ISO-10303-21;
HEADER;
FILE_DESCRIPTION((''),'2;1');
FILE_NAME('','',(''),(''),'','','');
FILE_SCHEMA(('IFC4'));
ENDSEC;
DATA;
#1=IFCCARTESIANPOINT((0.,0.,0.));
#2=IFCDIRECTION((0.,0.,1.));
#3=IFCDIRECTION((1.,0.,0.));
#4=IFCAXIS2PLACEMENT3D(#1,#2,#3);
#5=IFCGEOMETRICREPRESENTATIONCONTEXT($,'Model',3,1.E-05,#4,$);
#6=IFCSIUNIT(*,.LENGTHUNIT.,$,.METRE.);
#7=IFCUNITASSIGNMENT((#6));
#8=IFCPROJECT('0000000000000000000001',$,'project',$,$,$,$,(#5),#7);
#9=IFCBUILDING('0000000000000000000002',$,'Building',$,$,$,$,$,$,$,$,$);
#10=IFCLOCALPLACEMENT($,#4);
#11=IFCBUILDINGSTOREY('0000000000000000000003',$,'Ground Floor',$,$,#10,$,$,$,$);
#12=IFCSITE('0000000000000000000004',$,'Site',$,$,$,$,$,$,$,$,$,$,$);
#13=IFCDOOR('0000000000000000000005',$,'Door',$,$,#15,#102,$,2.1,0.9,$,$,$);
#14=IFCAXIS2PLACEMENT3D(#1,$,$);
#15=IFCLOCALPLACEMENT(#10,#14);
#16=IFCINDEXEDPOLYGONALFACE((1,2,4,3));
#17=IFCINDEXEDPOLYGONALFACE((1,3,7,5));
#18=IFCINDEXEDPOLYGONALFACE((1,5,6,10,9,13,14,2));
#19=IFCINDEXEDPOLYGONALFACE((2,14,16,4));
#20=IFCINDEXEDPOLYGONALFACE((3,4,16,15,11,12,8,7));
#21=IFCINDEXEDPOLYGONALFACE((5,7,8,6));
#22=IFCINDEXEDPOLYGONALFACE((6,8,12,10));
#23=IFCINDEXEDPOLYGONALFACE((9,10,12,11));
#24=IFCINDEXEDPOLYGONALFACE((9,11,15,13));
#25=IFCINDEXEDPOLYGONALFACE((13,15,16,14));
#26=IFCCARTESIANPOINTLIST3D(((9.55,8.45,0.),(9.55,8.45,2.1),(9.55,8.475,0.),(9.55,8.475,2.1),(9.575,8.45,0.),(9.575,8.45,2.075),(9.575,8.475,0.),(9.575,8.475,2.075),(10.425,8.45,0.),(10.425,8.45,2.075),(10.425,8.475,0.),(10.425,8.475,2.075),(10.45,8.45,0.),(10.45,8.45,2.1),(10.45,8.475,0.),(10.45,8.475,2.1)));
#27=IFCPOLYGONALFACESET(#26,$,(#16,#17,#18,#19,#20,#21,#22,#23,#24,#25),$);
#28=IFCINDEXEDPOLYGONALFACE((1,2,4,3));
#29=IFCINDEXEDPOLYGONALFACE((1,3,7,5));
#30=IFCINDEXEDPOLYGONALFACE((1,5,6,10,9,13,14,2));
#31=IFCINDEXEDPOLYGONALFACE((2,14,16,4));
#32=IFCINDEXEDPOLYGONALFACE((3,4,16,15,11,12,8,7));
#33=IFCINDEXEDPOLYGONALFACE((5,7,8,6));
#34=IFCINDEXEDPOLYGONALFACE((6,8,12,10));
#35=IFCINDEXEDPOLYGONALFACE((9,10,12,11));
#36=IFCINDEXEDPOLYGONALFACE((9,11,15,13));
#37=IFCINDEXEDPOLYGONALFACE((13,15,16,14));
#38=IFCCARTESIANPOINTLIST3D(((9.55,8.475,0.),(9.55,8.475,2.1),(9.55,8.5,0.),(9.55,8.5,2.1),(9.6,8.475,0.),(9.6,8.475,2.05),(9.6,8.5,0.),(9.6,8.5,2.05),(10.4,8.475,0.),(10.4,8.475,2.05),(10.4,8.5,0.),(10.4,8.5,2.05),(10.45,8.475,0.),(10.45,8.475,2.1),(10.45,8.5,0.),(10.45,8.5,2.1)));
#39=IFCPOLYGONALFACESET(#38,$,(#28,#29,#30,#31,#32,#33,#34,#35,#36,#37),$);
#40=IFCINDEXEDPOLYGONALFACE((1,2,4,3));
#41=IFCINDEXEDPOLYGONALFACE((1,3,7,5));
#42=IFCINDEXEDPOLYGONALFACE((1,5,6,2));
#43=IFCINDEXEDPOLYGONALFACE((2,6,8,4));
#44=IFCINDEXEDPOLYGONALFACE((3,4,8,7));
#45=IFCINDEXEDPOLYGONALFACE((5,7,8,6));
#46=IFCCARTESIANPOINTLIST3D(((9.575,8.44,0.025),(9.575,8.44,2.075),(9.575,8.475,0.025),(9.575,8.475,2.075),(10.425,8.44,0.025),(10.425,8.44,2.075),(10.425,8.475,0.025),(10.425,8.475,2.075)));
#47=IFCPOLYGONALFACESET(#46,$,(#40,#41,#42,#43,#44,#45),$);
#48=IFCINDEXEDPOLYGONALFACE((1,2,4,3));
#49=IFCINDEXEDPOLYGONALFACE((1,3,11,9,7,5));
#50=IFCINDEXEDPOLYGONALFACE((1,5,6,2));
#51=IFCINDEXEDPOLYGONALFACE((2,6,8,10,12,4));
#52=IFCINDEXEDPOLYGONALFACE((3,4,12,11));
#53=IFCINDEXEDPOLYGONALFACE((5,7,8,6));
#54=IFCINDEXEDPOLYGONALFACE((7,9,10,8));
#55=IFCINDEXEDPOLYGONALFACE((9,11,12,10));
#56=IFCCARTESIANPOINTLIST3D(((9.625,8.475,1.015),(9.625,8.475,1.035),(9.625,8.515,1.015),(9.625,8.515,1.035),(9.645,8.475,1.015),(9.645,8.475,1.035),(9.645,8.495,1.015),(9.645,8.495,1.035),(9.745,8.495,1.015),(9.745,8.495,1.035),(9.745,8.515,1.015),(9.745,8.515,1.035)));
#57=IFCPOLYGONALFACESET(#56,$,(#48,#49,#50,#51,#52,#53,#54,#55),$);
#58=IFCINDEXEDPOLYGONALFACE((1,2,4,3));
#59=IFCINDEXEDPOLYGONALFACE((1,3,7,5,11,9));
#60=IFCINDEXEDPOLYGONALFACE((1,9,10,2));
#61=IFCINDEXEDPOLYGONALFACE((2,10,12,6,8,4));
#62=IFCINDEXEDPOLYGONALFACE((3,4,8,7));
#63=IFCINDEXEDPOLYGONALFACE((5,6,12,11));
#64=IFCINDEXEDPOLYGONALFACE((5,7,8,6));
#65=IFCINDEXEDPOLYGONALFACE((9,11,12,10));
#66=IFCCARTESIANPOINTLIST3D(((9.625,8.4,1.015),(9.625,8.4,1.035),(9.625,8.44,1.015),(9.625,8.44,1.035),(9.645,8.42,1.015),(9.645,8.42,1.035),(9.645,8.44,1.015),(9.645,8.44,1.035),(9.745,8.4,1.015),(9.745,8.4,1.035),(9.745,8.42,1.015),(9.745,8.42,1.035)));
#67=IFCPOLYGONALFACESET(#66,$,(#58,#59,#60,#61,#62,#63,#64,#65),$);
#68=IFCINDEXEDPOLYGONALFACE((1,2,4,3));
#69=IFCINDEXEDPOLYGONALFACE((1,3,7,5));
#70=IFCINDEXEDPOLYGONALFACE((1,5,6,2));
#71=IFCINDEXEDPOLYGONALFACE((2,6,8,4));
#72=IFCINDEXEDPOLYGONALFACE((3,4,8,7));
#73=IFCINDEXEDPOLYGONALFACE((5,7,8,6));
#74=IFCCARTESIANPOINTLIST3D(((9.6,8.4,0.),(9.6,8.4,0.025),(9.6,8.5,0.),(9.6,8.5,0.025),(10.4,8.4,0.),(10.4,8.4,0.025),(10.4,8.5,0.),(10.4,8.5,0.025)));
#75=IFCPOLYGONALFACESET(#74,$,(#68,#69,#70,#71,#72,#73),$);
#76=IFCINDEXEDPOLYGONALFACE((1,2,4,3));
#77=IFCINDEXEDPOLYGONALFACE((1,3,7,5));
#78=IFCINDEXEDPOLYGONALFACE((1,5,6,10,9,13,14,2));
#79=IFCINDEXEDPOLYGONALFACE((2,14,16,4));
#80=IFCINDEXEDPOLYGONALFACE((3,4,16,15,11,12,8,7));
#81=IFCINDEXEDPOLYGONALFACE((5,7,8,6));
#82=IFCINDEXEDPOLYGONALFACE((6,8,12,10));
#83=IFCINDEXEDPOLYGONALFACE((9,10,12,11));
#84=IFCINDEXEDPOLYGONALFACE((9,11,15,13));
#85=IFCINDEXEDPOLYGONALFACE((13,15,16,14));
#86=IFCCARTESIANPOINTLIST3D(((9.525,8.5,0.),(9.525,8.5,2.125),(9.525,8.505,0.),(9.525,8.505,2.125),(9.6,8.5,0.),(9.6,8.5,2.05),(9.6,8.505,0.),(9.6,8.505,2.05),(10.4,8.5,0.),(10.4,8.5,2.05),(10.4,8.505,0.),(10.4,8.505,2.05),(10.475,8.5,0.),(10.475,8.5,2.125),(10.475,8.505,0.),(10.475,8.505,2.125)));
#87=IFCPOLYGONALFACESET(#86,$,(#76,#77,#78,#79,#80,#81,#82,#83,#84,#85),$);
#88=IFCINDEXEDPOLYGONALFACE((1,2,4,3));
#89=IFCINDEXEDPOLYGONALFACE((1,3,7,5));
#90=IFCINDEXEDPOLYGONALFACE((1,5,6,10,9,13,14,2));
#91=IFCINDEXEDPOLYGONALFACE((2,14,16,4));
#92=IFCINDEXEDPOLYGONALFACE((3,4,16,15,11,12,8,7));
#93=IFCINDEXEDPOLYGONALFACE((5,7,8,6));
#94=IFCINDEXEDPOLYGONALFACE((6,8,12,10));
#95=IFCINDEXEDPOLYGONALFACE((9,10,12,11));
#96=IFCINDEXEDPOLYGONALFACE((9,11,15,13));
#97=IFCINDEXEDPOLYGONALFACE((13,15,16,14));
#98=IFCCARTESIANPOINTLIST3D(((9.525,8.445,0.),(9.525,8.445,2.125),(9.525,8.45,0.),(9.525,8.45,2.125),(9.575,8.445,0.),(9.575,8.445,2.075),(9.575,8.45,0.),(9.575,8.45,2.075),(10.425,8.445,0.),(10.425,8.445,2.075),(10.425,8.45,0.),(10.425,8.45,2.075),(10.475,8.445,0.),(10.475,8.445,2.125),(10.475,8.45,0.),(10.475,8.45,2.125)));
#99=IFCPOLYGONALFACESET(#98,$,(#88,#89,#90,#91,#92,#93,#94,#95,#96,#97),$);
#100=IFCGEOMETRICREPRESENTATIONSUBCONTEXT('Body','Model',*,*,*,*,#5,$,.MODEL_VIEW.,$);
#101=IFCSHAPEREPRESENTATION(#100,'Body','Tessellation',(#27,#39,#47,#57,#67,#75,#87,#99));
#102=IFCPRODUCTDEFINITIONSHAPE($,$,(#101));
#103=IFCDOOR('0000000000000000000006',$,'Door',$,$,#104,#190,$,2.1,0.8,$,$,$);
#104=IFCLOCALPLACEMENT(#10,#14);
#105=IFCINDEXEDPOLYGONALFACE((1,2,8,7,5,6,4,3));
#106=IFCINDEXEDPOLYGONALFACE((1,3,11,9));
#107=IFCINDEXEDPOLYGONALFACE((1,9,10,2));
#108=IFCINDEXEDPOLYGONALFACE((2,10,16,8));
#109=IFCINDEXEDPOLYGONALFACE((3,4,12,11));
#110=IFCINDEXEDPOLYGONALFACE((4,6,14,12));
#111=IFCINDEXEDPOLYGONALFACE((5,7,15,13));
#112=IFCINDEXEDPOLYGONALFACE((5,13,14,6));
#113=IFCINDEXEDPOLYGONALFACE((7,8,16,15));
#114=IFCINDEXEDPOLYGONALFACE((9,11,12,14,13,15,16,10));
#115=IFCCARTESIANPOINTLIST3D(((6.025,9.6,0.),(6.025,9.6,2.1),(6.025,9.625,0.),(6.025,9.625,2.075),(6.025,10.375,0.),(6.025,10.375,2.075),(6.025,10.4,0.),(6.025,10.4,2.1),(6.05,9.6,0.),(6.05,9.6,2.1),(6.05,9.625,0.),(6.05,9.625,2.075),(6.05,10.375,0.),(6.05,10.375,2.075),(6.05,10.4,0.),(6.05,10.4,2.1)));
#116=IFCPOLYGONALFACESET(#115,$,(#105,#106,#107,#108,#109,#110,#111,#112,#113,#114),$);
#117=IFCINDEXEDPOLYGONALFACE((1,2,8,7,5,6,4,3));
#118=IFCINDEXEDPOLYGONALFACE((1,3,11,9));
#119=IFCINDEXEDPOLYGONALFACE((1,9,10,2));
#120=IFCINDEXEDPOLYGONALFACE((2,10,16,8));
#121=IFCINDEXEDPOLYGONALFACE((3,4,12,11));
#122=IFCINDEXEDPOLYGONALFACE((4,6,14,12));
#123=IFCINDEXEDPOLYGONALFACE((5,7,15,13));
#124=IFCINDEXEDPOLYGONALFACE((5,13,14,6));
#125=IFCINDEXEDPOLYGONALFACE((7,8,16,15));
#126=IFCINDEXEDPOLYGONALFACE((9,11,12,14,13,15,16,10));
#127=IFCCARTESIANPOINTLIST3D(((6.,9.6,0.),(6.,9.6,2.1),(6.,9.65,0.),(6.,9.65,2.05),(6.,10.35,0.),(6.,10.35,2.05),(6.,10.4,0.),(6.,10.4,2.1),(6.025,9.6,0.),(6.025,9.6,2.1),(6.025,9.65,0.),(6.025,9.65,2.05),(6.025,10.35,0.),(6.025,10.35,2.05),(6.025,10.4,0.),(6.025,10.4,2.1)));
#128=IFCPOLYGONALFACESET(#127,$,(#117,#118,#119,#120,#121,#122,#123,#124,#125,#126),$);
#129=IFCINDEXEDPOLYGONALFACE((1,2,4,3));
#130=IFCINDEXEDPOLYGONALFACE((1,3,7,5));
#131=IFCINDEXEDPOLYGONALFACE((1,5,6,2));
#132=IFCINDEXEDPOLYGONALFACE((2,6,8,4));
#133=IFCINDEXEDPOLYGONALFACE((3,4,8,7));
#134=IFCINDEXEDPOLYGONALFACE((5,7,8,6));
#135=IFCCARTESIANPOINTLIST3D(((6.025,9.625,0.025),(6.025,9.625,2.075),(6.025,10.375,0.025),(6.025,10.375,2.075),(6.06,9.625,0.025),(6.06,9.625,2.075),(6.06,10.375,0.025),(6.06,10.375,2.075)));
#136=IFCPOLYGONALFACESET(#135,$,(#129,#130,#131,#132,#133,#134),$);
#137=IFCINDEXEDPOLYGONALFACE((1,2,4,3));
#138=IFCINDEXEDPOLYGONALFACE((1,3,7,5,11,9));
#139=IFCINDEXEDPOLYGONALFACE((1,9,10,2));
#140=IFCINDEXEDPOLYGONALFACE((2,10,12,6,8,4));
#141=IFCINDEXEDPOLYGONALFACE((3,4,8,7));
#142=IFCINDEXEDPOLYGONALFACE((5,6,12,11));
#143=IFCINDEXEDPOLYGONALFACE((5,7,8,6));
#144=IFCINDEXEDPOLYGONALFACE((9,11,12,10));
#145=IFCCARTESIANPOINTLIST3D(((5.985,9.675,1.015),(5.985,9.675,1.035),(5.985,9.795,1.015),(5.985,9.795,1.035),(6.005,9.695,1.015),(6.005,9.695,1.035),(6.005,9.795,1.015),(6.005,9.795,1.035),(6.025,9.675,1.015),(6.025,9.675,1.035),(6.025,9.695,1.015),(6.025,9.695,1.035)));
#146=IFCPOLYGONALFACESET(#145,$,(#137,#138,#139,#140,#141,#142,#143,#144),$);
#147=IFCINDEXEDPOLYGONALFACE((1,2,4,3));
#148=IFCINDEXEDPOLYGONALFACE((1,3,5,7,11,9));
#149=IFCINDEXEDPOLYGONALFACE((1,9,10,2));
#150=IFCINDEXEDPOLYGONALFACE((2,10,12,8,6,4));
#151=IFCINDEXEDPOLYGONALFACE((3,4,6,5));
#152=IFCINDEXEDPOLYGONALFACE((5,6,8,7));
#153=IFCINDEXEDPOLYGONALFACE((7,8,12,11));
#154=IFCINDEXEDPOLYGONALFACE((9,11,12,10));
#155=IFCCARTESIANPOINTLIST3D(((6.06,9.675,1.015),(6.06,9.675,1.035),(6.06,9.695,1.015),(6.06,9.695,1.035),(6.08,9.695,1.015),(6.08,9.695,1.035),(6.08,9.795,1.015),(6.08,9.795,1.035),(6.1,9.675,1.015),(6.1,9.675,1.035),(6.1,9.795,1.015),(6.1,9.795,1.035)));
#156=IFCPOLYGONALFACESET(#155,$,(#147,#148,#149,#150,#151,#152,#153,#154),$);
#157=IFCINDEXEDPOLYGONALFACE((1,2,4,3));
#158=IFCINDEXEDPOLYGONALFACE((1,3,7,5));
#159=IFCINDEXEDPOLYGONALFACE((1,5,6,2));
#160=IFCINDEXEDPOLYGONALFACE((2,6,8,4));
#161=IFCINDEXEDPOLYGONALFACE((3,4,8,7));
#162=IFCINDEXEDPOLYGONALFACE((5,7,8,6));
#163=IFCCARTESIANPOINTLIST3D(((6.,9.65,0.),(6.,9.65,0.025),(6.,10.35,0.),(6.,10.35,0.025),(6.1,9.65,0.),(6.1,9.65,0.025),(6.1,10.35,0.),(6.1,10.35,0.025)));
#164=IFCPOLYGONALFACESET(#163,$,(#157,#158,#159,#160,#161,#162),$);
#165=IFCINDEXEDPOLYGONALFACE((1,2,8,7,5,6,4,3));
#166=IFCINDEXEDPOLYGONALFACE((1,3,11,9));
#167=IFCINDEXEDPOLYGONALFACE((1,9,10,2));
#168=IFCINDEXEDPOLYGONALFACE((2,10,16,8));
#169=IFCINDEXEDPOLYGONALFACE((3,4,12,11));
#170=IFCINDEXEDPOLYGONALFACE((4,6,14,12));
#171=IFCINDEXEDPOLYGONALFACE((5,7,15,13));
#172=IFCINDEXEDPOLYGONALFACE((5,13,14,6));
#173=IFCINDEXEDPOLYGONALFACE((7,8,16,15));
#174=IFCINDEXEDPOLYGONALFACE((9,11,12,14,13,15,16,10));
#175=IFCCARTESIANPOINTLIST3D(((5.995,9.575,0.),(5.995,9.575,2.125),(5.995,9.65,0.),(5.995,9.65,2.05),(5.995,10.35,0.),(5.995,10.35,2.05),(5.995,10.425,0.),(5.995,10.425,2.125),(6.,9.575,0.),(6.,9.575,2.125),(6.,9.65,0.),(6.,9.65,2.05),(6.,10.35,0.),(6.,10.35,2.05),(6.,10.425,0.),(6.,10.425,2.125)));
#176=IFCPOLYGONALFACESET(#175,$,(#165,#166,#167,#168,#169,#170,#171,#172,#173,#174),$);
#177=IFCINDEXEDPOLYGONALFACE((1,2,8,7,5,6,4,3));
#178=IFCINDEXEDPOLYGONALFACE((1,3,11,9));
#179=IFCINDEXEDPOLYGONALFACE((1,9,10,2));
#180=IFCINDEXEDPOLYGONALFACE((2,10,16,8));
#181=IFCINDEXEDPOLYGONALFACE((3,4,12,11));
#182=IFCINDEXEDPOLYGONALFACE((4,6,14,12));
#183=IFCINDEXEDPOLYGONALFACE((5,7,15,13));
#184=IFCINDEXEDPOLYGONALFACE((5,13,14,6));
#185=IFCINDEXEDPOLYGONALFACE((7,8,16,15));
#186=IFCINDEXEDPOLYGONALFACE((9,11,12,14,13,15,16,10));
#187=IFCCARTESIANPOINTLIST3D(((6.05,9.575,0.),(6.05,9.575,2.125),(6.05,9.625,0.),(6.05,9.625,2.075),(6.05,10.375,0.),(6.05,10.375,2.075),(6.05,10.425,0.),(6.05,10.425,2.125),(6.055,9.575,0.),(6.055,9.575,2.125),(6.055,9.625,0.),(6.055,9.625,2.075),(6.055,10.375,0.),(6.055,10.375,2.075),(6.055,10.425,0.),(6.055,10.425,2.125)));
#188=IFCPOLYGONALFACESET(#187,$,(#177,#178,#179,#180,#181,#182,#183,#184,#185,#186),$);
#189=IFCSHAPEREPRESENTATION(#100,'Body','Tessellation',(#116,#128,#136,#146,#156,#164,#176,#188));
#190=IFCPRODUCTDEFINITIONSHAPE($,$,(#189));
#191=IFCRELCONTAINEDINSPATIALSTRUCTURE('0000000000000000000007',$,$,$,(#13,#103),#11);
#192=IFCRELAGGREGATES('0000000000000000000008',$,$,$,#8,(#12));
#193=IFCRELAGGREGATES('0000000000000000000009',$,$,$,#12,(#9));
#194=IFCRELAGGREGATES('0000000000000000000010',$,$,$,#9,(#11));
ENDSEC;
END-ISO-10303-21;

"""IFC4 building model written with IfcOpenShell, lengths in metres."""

from ifc_helpers import new_model, si_unit, frame, origin_with_axes, place, context, subcontext, project, spatial, line, indexed_curve, outline, extrude, element, save


model = new_model("IFC4")

# Units and contexts
model_context = context("Model", 3, precision=1e-05, world=origin_with_axes())
body_context = subcontext(model_context, "Body", "Model", "MODEL_VIEW")
ifc_project = project(units=[si_unit("LENGTHUNIT", "METRE")], contexts=[model_context])

# Site, building, storey
site = spatial("IfcSite", under=ifc_project, Name="Site")
building = spatial("IfcBuilding", under=site, Name="Building")
storey_placement = place(None, origin_with_axes())
storey = spatial("IfcBuildingStorey", under=building, at=storey_placement, Name="Ground Floor")

# Doors
door_1_placement = place(storey_placement, frame((10.45, 8.5, 0.0), z_axis=(0.0, 0.0, 1.0), x_axis=(-1.0, 0.0, 0.0)))
element("IfcDoor", 1, at=door_1_placement, inside=storey, Name="Door", OverallHeight=2.1, OverallWidth=0.9, context=body_context, shape_type="SweptSolid", body=[
    extrude(outline(indexed_curve([(0.0, 0.0), (0.0, 2.1), (0.9, 2.1), (0.9, 0.0), (0.875, 0.0), (0.875, 2.075), (0.025, 2.075), (0.025, 0.0)], segments=[line(1, 2, 3, 4, 5, 6, 7, 8, 1)])), frame((0.0, 0.025, 0.0), z_axis=(0.0, -1.0, 0.0), x_axis=(1.0, 0.0, 0.0)), (0.0, 0.0, -1.0), 0.025),
    extrude(outline(indexed_curve([(0.0, 0.0), (0.0, 2.1), (0.9, 2.1), (0.9, 0.0), (0.85, 0.0), (0.85, 2.05), (0.05, 2.05), (0.05, 0.0)], segments=[line(1, 2, 3, 4, 5, 6, 7, 8, 1)])), frame((0.0, 0.0, 0.0), z_axis=(0.0, -1.0, 0.0), x_axis=(1.0, 0.0, 0.0)), (0.0, 0.0, -1.0), 0.025),
    extrude(outline(indexed_curve([(0.0, 0.0), (0.85, 0.0), (0.85, 0.035), (0.0, 0.035)], segments=[line(1, 2, 3, 4, 1)])), frame((0.025, 0.025, 0.025), z_axis=(0.0, 0.0, 1.0), x_axis=(1.0, 0.0, 0.0)), (0.0, 0.0, 1.0), 2.05),
    extrude(outline(indexed_curve([(0.0, 0.0), (0.0, -0.04), (-0.12, -0.04), (-0.12, -0.02), (-0.02, -0.02), (-0.02, 0.0)], segments=[line(1, 2, 3, 4, 5, 6, 1)])), frame((0.825, 0.025, 1.015), z_axis=(0.0, 0.0, 1.0), x_axis=(1.0, 0.0, 0.0)), (0.0, 0.0, 1.0), 0.02),
    extrude(outline(indexed_curve([(0.0, 0.0), (0.0, 0.04), (-0.12, 0.04), (-0.12, 0.02), (-0.02, 0.02), (-0.02, 0.0)], segments=[line(1, 2, 3, 4, 5, 6, 1)])), frame((0.825, 0.06, 1.015), z_axis=(0.0, 0.0, 1.0), x_axis=(1.0, 0.0, 0.0)), (0.0, 0.0, 1.0), 0.02),
    extrude(outline(indexed_curve([(0.0, 0.0), (0.8, 0.0), (0.8, 0.1), (0.0, 0.1)], segments=[line(1, 2, 3, 4, 1)])), frame((0.05, 0.0, 0.0), z_axis=(0.0, 0.0, 1.0), x_axis=(1.0, 0.0, 0.0)), (0.0, 0.0, 1.0), 0.025),
    extrude(outline(indexed_curve([(0.0, 0.0), (0.0, 2.125), (0.95, 2.125), (0.95, 0.0), (0.875, 0.0), (0.875, 2.05), (0.075, 2.05), (0.075, 0.0)], segments=[line(1, 2, 3, 4, 5, 6, 7, 8, 1)])), frame((-0.025, -0.005, 0.0), z_axis=(0.0, -1.0, 0.0), x_axis=(1.0, 0.0, 0.0)), (0.0, 0.0, -1.0), 0.005),
    extrude(outline(indexed_curve([(0.0, 0.0), (0.0, 2.125), (0.95, 2.125), (0.95, 0.0), (0.9, 0.0), (0.9, 2.075), (0.05, 2.075), (0.05, 0.0)], segments=[line(1, 2, 3, 4, 5, 6, 7, 8, 1)])), frame((-0.025, 0.05, 0.0), z_axis=(0.0, -1.0, 0.0), x_axis=(1.0, 0.0, 0.0)), (0.0, 0.0, -1.0), 0.005),
])
door_2_placement = place(storey_placement, frame((6.0, 10.4, 0.0), z_axis=(0.0, 0.0, 1.0), x_axis=(0.0, -1.0, 0.0)))
element("IfcDoor", 2, at=door_2_placement, inside=storey, Name="Door", OverallHeight=2.1, OverallWidth=0.8, context=body_context, shape_type="SweptSolid", body=[
    extrude(outline(indexed_curve([(0.0, 0.0), (0.0, 2.1), (0.8, 2.1), (0.8, 0.0), (0.775, 0.0), (0.775, 2.075), (0.025, 2.075), (0.025, 0.0)], segments=[line(1, 2, 3, 4, 5, 6, 7, 8, 1)])), frame((0.0, 0.025, 0.0), z_axis=(0.0, -1.0, 0.0), x_axis=(1.0, 0.0, 0.0)), (0.0, 0.0, -1.0), 0.025),
    extrude(outline(indexed_curve([(0.0, 0.0), (0.0, 2.1), (0.8, 2.1), (0.8, 0.0), (0.75, 0.0), (0.75, 2.05), (0.05, 2.05), (0.05, 0.0)], segments=[line(1, 2, 3, 4, 5, 6, 7, 8, 1)])), frame((0.0, 0.0, 0.0), z_axis=(0.0, -1.0, 0.0), x_axis=(1.0, 0.0, 0.0)), (0.0, 0.0, -1.0), 0.025),
    extrude(outline(indexed_curve([(0.0, 0.0), (0.75, 0.0), (0.75, 0.035), (0.0, 0.035)], segments=[line(1, 2, 3, 4, 1)])), frame((0.025, 0.025, 0.025), z_axis=(0.0, 0.0, 1.0), x_axis=(1.0, 0.0, 0.0)), (0.0, 0.0, 1.0), 2.05),
    extrude(outline(indexed_curve([(0.0, 0.0), (0.0, -0.04), (-0.12, -0.04), (-0.12, -0.02), (-0.02, -0.02), (-0.02, 0.0)], segments=[line(1, 2, 3, 4, 5, 6, 1)])), frame((0.725, 0.025, 1.015), z_axis=(0.0, 0.0, 1.0), x_axis=(1.0, 0.0, 0.0)), (0.0, 0.0, 1.0), 0.02),
    extrude(outline(indexed_curve([(0.0, 0.0), (0.0, 0.04), (-0.12, 0.04), (-0.12, 0.02), (-0.02, 0.02), (-0.02, 0.0)], segments=[line(1, 2, 3, 4, 5, 6, 1)])), frame((0.725, 0.06, 1.015), z_axis=(0.0, 0.0, 1.0), x_axis=(1.0, 0.0, 0.0)), (0.0, 0.0, 1.0), 0.02),
    extrude(outline(indexed_curve([(0.0, 0.0), (0.7, 0.0), (0.7, 0.1), (0.0, 0.1)], segments=[line(1, 2, 3, 4, 1)])), frame((0.05, 0.0, 0.0), z_axis=(0.0, 0.0, 1.0), x_axis=(1.0, 0.0, 0.0)), (0.0, 0.0, 1.0), 0.025),
    extrude(outline(indexed_curve([(0.0, 0.0), (0.0, 2.125), (0.85, 2.125), (0.85, 0.0), (0.775, 0.0), (0.775, 2.05), (0.075, 2.05), (0.075, 0.0)], segments=[line(1, 2, 3, 4, 5, 6, 7, 8, 1)])), frame((-0.025, -0.005, 0.0), z_axis=(0.0, -1.0, 0.0), x_axis=(1.0, 0.0, 0.0)), (0.0, 0.0, -1.0), 0.005),
    extrude(outline(indexed_curve([(0.0, 0.0), (0.0, 2.125), (0.85, 2.125), (0.85, 0.0), (0.8, 0.0), (0.8, 2.075), (0.05, 2.075), (0.05, 0.0)], segments=[line(1, 2, 3, 4, 5, 6, 7, 8, 1)])), frame((-0.025, 0.05, 0.0), z_axis=(0.0, -1.0, 0.0), x_axis=(1.0, 0.0, 0.0)), (0.0, 0.0, -1.0), 0.005),
])

save(model, "model.ifc")
